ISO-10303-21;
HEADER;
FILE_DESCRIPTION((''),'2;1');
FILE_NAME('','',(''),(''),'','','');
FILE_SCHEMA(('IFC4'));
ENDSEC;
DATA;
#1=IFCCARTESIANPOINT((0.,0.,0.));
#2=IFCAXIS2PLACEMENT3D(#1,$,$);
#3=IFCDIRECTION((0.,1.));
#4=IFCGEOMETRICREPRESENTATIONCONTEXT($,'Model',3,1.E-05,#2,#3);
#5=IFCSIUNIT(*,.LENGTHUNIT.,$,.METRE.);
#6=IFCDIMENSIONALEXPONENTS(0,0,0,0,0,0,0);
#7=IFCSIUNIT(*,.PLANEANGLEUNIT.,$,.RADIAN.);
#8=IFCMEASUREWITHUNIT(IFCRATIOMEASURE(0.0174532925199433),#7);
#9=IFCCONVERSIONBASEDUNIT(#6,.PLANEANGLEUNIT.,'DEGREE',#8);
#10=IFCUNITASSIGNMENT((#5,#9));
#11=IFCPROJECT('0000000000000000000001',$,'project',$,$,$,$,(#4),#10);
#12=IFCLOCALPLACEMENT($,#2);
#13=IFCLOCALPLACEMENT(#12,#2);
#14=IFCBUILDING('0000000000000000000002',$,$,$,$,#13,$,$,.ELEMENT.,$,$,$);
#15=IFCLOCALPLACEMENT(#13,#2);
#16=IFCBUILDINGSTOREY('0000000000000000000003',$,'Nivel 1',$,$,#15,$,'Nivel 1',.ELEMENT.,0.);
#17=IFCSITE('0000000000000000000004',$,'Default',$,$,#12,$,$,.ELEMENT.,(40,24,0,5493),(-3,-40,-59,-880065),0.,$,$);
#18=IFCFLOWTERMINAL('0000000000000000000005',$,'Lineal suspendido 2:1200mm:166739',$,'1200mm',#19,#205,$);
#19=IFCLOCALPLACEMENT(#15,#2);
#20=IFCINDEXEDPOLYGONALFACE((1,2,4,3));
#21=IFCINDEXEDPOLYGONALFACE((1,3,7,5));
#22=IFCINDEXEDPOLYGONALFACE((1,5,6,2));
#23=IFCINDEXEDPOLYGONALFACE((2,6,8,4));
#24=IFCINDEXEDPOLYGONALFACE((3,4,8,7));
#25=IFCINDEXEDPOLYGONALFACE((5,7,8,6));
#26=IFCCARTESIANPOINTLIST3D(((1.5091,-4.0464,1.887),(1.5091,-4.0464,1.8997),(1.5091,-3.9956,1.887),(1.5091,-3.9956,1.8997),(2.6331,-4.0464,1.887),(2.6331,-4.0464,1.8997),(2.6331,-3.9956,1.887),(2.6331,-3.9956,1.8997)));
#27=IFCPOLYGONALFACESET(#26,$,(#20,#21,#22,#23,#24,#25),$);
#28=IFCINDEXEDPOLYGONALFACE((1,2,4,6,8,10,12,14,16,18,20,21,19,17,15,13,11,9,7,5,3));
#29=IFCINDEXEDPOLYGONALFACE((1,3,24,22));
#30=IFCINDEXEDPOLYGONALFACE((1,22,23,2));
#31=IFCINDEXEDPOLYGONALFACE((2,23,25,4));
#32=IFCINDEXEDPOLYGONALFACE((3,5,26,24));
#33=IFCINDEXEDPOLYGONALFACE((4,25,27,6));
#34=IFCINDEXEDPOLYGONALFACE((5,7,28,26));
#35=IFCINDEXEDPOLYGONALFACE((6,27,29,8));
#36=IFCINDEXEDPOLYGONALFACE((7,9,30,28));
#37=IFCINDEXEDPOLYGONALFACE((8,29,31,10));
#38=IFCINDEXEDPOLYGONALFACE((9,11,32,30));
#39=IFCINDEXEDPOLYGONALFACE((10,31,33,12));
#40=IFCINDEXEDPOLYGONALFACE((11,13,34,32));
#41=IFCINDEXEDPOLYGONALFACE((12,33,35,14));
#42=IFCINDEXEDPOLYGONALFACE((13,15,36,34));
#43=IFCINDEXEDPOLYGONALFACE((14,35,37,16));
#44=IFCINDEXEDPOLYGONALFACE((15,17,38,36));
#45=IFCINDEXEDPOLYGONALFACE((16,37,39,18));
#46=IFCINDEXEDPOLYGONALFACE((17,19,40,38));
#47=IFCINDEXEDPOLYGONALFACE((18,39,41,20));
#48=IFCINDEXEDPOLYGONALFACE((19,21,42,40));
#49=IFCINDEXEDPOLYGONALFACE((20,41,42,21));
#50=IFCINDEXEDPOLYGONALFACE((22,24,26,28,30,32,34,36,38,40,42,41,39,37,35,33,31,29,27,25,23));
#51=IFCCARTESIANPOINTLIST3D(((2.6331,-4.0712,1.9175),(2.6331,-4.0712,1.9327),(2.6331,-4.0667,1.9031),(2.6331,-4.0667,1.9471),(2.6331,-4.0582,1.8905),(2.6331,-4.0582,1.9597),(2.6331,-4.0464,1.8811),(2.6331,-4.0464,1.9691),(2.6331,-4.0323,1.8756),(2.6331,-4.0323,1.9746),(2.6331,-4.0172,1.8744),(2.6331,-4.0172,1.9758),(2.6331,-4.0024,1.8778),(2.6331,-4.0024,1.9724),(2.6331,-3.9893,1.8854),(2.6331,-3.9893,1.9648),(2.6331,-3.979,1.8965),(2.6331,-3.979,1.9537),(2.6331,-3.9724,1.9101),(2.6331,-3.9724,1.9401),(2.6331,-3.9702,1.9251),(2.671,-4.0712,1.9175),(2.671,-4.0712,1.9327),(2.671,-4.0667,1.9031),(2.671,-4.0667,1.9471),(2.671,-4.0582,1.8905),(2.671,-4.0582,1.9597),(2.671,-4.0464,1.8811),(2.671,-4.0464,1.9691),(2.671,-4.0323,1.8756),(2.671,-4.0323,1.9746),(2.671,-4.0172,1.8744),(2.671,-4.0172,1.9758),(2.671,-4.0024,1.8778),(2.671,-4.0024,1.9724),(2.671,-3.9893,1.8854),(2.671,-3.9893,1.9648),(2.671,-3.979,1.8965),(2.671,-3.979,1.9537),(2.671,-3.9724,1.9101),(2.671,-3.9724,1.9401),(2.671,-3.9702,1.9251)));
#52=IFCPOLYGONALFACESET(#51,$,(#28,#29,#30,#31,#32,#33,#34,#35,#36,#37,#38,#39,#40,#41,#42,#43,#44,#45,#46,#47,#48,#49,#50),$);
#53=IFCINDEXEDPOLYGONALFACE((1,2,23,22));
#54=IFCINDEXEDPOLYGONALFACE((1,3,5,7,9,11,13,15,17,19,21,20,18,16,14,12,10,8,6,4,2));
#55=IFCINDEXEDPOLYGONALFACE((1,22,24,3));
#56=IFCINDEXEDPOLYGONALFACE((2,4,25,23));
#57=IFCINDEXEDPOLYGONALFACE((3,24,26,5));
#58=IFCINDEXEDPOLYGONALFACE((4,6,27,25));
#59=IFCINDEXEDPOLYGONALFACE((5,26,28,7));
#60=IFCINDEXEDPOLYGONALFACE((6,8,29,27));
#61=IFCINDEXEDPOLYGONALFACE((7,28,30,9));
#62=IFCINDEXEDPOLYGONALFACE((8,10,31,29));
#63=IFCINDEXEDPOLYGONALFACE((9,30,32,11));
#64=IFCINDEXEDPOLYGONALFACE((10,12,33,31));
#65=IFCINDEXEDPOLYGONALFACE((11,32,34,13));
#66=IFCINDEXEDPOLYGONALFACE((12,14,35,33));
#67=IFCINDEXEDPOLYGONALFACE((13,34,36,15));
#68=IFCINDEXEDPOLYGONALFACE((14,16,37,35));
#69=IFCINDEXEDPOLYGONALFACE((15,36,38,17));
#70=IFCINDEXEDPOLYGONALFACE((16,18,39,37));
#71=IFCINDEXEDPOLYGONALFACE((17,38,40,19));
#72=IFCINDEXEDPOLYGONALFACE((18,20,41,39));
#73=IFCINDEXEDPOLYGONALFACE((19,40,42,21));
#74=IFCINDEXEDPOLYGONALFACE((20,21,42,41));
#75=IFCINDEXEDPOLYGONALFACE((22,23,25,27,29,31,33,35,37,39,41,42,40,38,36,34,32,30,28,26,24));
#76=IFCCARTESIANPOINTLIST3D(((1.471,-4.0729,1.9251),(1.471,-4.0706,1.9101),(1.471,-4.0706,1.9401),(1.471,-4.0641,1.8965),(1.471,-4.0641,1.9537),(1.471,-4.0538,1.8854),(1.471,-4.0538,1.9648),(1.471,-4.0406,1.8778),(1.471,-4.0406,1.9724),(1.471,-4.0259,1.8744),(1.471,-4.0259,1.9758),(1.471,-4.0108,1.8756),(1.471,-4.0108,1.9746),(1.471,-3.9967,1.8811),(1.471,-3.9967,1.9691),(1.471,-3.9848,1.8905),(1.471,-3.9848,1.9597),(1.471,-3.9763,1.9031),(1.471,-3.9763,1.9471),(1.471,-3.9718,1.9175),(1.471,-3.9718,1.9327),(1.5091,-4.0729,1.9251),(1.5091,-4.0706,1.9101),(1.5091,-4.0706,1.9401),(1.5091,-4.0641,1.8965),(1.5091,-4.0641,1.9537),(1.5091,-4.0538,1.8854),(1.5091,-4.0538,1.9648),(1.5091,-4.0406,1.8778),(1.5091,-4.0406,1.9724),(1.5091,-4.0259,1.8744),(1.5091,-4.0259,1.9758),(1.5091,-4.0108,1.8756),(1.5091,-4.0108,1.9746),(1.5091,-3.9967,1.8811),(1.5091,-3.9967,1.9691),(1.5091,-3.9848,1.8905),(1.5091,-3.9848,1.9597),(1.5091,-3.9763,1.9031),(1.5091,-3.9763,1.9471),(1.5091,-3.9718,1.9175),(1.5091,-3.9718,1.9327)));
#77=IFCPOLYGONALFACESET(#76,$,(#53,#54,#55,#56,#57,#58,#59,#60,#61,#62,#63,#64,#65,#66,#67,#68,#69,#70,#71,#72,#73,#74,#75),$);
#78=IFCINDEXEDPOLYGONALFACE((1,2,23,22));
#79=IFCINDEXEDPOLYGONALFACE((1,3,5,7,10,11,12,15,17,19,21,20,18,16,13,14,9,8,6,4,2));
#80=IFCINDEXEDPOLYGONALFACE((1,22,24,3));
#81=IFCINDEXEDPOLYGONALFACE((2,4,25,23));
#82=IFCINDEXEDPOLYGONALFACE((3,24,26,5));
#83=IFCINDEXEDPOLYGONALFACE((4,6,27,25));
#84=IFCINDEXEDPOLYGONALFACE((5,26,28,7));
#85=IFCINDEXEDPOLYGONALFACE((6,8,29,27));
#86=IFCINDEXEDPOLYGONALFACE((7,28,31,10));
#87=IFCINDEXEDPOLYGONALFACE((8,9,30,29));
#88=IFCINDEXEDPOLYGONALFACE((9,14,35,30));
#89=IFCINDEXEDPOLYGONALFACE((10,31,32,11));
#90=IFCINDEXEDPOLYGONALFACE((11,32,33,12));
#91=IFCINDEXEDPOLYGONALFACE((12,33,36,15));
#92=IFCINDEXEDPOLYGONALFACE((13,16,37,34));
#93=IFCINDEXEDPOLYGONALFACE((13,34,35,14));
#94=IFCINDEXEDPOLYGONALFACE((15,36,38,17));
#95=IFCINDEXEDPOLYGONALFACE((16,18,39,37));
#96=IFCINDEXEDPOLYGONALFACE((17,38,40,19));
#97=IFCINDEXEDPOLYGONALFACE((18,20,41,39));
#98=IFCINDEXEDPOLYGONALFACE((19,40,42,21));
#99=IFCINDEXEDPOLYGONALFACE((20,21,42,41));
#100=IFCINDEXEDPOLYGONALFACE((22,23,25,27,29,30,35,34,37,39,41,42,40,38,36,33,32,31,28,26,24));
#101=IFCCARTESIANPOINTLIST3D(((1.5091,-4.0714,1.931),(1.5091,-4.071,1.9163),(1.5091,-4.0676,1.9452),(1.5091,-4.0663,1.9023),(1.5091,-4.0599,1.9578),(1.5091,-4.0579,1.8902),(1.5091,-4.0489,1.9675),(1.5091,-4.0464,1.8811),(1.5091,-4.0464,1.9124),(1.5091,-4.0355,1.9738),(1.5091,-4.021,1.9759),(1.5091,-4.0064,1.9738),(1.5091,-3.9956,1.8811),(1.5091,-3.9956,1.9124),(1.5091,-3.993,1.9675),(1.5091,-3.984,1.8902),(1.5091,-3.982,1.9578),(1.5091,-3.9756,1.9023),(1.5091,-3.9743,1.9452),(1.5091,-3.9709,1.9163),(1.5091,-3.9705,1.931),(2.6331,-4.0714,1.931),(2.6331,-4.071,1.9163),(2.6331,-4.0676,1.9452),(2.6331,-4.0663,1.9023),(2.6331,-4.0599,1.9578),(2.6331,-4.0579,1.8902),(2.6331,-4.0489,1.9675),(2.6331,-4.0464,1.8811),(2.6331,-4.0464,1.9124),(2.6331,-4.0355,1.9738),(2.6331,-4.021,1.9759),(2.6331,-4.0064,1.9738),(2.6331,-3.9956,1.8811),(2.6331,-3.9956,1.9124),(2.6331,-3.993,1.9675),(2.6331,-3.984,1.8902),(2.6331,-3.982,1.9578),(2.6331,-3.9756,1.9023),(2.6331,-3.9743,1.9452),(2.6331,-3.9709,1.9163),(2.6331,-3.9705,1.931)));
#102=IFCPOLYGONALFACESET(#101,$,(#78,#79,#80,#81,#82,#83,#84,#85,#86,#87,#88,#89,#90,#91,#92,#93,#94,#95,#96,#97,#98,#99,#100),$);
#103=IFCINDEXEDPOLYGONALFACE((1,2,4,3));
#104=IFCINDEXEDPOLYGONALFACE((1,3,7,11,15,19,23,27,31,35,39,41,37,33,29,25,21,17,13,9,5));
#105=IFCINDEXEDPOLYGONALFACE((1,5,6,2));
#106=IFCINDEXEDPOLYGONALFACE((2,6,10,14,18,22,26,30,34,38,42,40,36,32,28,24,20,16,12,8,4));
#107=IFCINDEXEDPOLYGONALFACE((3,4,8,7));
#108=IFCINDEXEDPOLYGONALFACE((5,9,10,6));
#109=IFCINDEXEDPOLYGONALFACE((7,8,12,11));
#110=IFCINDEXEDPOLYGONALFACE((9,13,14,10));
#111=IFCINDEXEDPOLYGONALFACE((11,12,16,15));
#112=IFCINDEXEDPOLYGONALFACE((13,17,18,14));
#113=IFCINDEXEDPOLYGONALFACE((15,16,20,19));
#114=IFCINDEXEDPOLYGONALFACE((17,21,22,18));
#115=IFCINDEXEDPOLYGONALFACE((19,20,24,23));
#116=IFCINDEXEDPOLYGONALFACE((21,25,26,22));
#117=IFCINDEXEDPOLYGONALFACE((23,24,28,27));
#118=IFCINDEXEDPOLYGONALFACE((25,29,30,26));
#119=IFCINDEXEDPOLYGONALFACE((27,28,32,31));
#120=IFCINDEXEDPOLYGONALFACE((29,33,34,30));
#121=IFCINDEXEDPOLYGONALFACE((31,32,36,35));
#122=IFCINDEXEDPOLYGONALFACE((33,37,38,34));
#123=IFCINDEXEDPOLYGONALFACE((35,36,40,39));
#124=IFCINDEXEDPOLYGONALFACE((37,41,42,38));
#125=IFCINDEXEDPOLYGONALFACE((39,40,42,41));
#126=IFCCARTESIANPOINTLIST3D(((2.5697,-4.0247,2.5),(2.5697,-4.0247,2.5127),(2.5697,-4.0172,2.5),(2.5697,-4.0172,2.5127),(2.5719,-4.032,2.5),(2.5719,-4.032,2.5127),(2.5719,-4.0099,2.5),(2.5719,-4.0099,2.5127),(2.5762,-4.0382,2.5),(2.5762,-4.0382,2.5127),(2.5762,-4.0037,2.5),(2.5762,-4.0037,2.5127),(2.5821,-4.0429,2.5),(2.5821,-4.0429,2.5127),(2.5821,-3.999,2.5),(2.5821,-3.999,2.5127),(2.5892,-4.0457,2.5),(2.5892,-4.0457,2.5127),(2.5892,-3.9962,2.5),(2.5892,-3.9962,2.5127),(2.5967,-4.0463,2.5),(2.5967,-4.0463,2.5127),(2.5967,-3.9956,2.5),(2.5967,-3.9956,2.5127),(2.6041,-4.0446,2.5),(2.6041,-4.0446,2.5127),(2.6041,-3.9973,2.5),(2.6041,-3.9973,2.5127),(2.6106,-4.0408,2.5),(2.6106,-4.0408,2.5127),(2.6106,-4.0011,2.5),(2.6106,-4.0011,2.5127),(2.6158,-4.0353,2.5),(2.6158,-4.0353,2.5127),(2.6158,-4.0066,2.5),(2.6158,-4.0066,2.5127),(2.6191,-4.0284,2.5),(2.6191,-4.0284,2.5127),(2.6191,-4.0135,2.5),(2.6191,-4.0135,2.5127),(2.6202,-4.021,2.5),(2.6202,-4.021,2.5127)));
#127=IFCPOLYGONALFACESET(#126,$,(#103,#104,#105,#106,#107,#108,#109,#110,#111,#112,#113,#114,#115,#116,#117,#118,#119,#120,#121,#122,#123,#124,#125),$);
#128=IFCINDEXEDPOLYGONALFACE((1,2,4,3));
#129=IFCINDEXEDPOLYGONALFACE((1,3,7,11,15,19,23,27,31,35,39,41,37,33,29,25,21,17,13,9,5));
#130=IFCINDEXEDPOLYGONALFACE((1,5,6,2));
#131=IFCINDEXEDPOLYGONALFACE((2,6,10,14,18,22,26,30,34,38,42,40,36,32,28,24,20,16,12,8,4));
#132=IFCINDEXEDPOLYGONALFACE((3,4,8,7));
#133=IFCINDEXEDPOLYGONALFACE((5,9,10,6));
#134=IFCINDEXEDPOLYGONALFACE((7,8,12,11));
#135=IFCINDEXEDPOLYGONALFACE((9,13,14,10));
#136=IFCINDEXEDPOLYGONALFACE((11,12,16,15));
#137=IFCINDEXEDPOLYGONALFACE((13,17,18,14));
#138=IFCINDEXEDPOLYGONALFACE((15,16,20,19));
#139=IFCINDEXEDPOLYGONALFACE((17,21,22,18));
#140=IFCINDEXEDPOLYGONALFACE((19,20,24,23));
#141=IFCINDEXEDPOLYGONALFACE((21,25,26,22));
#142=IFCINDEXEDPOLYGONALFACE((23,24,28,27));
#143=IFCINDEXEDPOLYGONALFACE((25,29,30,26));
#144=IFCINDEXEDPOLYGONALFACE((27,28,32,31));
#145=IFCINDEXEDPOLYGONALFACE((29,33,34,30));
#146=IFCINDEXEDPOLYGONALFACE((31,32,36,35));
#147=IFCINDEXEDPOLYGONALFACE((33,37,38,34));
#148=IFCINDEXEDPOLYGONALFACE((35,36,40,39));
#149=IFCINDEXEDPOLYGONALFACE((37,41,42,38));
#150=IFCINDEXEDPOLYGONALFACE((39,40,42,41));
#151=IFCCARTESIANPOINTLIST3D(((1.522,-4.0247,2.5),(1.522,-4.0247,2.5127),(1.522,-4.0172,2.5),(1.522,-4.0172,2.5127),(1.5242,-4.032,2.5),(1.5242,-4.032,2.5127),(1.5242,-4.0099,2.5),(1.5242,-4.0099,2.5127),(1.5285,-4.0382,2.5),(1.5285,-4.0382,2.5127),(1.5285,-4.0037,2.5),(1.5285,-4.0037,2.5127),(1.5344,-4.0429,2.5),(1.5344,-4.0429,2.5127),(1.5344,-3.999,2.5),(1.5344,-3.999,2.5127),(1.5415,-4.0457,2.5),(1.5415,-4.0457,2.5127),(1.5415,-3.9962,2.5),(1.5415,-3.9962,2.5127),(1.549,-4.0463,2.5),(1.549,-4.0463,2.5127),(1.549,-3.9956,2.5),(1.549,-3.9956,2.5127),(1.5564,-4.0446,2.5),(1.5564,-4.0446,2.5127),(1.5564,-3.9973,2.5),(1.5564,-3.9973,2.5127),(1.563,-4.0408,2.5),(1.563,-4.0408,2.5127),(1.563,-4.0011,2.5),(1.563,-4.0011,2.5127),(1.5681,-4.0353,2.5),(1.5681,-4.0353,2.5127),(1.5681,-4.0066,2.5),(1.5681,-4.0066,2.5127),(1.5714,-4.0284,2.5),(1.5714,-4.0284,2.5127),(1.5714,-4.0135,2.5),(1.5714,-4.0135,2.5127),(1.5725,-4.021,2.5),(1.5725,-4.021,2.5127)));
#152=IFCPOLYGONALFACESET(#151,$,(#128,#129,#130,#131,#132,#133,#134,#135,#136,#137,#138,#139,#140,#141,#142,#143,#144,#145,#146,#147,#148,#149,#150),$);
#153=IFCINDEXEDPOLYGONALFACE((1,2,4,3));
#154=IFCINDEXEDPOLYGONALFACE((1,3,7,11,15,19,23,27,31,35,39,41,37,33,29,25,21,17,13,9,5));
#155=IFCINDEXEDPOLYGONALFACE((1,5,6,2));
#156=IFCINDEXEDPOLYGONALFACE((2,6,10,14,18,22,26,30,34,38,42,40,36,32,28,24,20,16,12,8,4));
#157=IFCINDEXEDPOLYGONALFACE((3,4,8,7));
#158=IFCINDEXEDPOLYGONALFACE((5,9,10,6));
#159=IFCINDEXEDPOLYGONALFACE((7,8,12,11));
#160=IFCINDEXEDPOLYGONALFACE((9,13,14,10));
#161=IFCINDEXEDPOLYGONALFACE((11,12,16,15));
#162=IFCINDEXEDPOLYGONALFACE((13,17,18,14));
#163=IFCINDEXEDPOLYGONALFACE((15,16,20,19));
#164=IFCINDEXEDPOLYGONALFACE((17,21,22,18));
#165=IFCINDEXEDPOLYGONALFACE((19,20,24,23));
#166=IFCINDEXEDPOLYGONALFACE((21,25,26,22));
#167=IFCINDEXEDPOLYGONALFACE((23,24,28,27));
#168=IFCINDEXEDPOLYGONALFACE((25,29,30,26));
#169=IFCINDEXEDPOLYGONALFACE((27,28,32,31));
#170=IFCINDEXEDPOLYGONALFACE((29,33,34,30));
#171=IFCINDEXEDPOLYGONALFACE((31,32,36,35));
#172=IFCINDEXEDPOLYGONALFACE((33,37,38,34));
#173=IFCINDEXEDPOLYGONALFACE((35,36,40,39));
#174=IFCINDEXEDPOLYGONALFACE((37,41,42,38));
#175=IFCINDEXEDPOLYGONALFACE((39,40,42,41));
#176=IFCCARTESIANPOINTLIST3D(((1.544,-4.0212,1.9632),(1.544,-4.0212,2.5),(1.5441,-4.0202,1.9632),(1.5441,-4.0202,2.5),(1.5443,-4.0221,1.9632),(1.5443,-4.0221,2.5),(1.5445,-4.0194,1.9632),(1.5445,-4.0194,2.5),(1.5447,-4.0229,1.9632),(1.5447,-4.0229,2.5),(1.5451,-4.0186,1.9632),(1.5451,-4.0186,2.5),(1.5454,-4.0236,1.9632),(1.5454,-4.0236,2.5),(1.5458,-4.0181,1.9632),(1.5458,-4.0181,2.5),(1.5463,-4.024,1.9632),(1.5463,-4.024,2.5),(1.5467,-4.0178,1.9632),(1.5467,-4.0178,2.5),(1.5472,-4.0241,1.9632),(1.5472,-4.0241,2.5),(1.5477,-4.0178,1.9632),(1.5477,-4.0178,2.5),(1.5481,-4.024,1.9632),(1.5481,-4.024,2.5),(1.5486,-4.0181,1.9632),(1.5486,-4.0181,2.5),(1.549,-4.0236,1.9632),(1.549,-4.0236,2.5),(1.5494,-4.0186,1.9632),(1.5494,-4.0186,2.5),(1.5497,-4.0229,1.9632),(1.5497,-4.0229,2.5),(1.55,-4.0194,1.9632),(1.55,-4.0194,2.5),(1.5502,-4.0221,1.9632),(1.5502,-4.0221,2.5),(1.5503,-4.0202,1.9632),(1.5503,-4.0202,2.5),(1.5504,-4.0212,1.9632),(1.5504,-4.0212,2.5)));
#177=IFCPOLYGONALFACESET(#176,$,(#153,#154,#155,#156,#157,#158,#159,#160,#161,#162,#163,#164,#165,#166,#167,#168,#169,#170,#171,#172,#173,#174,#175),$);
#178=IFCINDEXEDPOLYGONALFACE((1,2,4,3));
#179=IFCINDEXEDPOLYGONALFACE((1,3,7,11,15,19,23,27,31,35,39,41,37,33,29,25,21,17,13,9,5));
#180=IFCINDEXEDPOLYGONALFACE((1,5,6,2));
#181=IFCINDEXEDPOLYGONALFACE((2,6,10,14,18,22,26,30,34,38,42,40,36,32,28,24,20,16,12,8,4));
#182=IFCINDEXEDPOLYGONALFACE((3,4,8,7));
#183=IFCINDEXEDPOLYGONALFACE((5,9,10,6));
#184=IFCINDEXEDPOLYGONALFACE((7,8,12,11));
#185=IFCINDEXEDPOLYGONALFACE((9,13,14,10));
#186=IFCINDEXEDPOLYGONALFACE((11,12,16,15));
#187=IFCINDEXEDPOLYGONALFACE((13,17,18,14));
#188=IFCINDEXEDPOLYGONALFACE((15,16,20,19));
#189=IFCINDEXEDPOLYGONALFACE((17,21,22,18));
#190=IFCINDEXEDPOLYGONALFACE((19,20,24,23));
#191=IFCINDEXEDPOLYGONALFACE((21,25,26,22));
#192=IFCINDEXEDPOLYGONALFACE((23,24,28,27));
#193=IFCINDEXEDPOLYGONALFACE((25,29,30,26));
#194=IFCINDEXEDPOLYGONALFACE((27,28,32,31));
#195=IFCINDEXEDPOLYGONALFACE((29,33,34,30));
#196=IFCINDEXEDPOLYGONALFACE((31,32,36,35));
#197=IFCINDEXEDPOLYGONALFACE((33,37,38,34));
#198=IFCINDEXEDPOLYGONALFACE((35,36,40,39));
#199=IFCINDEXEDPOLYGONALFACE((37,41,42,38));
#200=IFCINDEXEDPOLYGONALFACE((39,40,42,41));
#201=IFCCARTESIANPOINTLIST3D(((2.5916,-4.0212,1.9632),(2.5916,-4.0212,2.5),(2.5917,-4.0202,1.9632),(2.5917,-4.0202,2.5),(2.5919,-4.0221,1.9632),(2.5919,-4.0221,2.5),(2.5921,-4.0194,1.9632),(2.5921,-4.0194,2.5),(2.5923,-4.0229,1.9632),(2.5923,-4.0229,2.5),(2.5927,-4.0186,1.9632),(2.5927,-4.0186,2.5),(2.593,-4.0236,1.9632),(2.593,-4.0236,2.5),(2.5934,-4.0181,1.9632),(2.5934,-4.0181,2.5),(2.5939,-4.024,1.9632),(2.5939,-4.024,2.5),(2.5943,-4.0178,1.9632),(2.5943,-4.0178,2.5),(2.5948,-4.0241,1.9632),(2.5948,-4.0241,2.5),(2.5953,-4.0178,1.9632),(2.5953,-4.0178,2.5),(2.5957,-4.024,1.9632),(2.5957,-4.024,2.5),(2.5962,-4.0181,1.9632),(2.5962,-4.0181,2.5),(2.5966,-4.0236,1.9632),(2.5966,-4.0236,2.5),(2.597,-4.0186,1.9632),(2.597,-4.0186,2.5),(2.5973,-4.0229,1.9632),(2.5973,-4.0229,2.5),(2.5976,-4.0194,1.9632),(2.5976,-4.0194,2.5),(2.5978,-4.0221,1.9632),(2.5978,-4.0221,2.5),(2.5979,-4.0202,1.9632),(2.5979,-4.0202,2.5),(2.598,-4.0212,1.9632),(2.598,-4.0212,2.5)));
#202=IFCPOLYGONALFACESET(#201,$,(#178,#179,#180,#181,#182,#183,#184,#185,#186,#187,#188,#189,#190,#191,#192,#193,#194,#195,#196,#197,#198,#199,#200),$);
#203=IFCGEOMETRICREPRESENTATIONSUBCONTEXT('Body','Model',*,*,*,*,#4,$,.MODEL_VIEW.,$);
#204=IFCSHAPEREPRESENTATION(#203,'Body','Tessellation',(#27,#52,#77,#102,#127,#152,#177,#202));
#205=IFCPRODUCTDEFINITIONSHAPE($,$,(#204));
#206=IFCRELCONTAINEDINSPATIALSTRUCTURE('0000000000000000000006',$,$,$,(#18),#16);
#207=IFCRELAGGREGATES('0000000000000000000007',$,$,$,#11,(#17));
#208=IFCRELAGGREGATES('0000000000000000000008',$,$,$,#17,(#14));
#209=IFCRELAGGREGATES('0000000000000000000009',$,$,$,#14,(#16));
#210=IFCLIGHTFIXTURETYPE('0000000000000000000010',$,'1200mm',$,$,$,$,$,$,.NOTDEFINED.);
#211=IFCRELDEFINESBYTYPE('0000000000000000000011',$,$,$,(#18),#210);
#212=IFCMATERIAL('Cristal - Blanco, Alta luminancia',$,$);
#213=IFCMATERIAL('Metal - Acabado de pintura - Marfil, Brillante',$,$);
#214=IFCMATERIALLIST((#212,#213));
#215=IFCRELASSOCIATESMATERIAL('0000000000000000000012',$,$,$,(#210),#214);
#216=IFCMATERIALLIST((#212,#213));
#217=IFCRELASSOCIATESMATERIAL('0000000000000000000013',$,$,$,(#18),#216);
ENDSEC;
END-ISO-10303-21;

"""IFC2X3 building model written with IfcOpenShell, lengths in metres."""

from ifc_helpers import new_model, entity, si_unit, converted_unit, direction, frame, frame_2d, origin, origin_2d_with_axis, place, context, subcontext, project, spatial, polyline, circle_curve, parameter, trimmed, segment, composite_curve, rectangle, circle, outline, extrude, source, transform, mapped, material, material_list, type_object, type_shapes, element, save


model = new_model("IFC2X3")

# Units and contexts
model_context = context("Model", 3, precision=1e-05, world=origin(), true_north=direction((0.0, 1.0)))
body_context = subcontext(model_context, "Body", "Model", "MODEL_VIEW")
ifc_project = project(units=[si_unit("LENGTHUNIT", "METRE"), converted_unit("PLANEANGLEUNIT", "DEGREE", entity("IfcRatioMeasure", 0.0174532925199433), si_unit("PLANEANGLEUNIT", "RADIAN"), dimensions=[0, 0, 0, 0, 0, 0, 0])], contexts=[model_context])

# Site, building, storey
site_placement = place(None, origin())
site = spatial("IfcSite", under=ifc_project, at=site_placement, Name="Default", CompositionType="ELEMENT", RefLatitude=(40, 24, 0, 5493), RefLongitude=(-3, -40, -59, -880065), RefElevation=0.0)
building_placement = place(site_placement, origin())
building = spatial("IfcBuilding", under=site, at=building_placement, CompositionType="ELEMENT")
storey_placement = place(building_placement, origin())
storey = spatial("IfcBuildingStorey", under=building, at=storey_placement, Name="Nivel 1", LongName="Nivel 1", CompositionType="ELEMENT", Elevation=0.0)

# Flow terminal
ifc_material_1 = material(Name="Cristal - Blanco, Alta luminancia")
ifc_material_2 = material(Name="Metal - Acabado de pintura - Marfil, Brillante")
ifc_material_list_1 = material_list([ifc_material_1, ifc_material_2])
light_fixture_type = type_object("IfcLightFixtureType", Name="1200mm", PredefinedType="NOTDEFINED", material=ifc_material_list_1)
shared_shape = source(origin(), body_context, "Body", "SweptSolid", [
    extrude(rectangle(XDim=1.124, YDim=0.0508, at=origin_2d_with_axis()), frame((0.0001, 0.0, 1.8127), z_axis=(0.0, 0.0, 1.0), x_axis=(-1.0, 0.0, 0.0)), (0.0, 0.0, 1.0), 0.0127),
    extrude(circle(Radius=0.0508, at=frame_2d((0.0, 0.0), x_axis=(1.0, 0.0))), frame((0.5621, 0.0, 1.8508), z_axis=(1.0, 0.0, 0.0), x_axis=(0.0, 1.0, 0.0)), (0.0, 0.0, 1.0), 0.0379),
    extrude(circle(Radius=0.0508, at=frame_2d((0.0, 0.0), x_axis=(1.0, 0.0))), frame((-0.6, -0.0011, 1.8508), z_axis=(1.0, 0.0, 0.0), x_axis=(0.0, -1.0, 0.0)), (0.0, 0.0, 1.0), 0.0381),
    extrude(outline(composite_curve([segment(trimmed(circle_curve(frame_2d((0.0125, 0.0), x_axis=(0.0, 1.0)), 0.0508), [parameter(120.0)], [parameter(270.0)], True, "PARAMETER"), True, "CONTINUOUS"), segment(trimmed(circle_curve(frame_2d((0.0125, 0.0), x_axis=(0.0, 1.0)), 0.0508), [parameter(270.0)], [parameter(60.0)], True, "PARAMETER"), True, "CONTINUOUS"), segment(polyline([(-0.0315, 0.0254), (-0.0002, 0.0254)]), True, "CONTINUOUS"), segment(polyline([(-0.0002, 0.0254), (-0.0002, -0.0254)]), True, "CONTINUOUS"), segment(polyline([(-0.0002, -0.0254), (-0.0315, -0.0254)]), True, "CONTINUOUS")], self_intersect=False)), frame((-0.5619, 0.0, 1.8383), z_axis=(-1.0, 0.0, 0.0), x_axis=(0.0, 0.0, 1.0)), (0.0, 0.0, -1.0), 1.124),
    extrude(circle(Radius=0.0254, at=frame_2d((0.0, 0.0), x_axis=(1.0, 0.0))), frame((0.5238, 0.0, 2.4257)), (0.0, 0.0, 1.0), 0.0127),
    extrude(circle(Radius=0.0254, at=frame_2d((0.0, 0.0), x_axis=(1.0, 0.0))), frame((-0.5239, 0.0, 2.4257)), (0.0, 0.0, 1.0), 0.0127),
    extrude(circle(Radius=0.0032, at=frame_2d((0.0, 0.0), x_axis=(1.0, 0.0))), frame((-0.5238, 0.0, 1.8889), z_axis=(0.0, 0.0, 1.0), x_axis=(0.0, -1.0, 0.0)), (0.0, 0.0, 1.0), 0.5368),
    extrude(circle(Radius=0.0032, at=frame_2d((0.0, 0.0), x_axis=(1.0, 0.0))), frame((0.5238, 0.0, 1.8889), z_axis=(0.0, 0.0, 1.0), x_axis=(0.0, -1.0, 0.0)), (0.0, 0.0, 1.0), 0.5368),
])
type_shapes(light_fixture_type, [shared_shape])
ifc_material_list_2 = material_list([ifc_material_1, ifc_material_2])
flow_terminal_1_placement = place(storey_placement, frame((2.071, -4.021, 0.0743)))
element("IfcFlowTerminal", 1, at=flow_terminal_1_placement, inside=storey, type_object=light_fixture_type, material=ifc_material_list_2, Name="Lineal suspendido 2:1200mm:166739", ObjectType="1200mm", context=body_context, shape_type="MappedRepresentation", body=[
    mapped(shared_shape, transform((0.0, 0.0, 0.0), scale=1.0)),
])

save(model, "model.ifc")
